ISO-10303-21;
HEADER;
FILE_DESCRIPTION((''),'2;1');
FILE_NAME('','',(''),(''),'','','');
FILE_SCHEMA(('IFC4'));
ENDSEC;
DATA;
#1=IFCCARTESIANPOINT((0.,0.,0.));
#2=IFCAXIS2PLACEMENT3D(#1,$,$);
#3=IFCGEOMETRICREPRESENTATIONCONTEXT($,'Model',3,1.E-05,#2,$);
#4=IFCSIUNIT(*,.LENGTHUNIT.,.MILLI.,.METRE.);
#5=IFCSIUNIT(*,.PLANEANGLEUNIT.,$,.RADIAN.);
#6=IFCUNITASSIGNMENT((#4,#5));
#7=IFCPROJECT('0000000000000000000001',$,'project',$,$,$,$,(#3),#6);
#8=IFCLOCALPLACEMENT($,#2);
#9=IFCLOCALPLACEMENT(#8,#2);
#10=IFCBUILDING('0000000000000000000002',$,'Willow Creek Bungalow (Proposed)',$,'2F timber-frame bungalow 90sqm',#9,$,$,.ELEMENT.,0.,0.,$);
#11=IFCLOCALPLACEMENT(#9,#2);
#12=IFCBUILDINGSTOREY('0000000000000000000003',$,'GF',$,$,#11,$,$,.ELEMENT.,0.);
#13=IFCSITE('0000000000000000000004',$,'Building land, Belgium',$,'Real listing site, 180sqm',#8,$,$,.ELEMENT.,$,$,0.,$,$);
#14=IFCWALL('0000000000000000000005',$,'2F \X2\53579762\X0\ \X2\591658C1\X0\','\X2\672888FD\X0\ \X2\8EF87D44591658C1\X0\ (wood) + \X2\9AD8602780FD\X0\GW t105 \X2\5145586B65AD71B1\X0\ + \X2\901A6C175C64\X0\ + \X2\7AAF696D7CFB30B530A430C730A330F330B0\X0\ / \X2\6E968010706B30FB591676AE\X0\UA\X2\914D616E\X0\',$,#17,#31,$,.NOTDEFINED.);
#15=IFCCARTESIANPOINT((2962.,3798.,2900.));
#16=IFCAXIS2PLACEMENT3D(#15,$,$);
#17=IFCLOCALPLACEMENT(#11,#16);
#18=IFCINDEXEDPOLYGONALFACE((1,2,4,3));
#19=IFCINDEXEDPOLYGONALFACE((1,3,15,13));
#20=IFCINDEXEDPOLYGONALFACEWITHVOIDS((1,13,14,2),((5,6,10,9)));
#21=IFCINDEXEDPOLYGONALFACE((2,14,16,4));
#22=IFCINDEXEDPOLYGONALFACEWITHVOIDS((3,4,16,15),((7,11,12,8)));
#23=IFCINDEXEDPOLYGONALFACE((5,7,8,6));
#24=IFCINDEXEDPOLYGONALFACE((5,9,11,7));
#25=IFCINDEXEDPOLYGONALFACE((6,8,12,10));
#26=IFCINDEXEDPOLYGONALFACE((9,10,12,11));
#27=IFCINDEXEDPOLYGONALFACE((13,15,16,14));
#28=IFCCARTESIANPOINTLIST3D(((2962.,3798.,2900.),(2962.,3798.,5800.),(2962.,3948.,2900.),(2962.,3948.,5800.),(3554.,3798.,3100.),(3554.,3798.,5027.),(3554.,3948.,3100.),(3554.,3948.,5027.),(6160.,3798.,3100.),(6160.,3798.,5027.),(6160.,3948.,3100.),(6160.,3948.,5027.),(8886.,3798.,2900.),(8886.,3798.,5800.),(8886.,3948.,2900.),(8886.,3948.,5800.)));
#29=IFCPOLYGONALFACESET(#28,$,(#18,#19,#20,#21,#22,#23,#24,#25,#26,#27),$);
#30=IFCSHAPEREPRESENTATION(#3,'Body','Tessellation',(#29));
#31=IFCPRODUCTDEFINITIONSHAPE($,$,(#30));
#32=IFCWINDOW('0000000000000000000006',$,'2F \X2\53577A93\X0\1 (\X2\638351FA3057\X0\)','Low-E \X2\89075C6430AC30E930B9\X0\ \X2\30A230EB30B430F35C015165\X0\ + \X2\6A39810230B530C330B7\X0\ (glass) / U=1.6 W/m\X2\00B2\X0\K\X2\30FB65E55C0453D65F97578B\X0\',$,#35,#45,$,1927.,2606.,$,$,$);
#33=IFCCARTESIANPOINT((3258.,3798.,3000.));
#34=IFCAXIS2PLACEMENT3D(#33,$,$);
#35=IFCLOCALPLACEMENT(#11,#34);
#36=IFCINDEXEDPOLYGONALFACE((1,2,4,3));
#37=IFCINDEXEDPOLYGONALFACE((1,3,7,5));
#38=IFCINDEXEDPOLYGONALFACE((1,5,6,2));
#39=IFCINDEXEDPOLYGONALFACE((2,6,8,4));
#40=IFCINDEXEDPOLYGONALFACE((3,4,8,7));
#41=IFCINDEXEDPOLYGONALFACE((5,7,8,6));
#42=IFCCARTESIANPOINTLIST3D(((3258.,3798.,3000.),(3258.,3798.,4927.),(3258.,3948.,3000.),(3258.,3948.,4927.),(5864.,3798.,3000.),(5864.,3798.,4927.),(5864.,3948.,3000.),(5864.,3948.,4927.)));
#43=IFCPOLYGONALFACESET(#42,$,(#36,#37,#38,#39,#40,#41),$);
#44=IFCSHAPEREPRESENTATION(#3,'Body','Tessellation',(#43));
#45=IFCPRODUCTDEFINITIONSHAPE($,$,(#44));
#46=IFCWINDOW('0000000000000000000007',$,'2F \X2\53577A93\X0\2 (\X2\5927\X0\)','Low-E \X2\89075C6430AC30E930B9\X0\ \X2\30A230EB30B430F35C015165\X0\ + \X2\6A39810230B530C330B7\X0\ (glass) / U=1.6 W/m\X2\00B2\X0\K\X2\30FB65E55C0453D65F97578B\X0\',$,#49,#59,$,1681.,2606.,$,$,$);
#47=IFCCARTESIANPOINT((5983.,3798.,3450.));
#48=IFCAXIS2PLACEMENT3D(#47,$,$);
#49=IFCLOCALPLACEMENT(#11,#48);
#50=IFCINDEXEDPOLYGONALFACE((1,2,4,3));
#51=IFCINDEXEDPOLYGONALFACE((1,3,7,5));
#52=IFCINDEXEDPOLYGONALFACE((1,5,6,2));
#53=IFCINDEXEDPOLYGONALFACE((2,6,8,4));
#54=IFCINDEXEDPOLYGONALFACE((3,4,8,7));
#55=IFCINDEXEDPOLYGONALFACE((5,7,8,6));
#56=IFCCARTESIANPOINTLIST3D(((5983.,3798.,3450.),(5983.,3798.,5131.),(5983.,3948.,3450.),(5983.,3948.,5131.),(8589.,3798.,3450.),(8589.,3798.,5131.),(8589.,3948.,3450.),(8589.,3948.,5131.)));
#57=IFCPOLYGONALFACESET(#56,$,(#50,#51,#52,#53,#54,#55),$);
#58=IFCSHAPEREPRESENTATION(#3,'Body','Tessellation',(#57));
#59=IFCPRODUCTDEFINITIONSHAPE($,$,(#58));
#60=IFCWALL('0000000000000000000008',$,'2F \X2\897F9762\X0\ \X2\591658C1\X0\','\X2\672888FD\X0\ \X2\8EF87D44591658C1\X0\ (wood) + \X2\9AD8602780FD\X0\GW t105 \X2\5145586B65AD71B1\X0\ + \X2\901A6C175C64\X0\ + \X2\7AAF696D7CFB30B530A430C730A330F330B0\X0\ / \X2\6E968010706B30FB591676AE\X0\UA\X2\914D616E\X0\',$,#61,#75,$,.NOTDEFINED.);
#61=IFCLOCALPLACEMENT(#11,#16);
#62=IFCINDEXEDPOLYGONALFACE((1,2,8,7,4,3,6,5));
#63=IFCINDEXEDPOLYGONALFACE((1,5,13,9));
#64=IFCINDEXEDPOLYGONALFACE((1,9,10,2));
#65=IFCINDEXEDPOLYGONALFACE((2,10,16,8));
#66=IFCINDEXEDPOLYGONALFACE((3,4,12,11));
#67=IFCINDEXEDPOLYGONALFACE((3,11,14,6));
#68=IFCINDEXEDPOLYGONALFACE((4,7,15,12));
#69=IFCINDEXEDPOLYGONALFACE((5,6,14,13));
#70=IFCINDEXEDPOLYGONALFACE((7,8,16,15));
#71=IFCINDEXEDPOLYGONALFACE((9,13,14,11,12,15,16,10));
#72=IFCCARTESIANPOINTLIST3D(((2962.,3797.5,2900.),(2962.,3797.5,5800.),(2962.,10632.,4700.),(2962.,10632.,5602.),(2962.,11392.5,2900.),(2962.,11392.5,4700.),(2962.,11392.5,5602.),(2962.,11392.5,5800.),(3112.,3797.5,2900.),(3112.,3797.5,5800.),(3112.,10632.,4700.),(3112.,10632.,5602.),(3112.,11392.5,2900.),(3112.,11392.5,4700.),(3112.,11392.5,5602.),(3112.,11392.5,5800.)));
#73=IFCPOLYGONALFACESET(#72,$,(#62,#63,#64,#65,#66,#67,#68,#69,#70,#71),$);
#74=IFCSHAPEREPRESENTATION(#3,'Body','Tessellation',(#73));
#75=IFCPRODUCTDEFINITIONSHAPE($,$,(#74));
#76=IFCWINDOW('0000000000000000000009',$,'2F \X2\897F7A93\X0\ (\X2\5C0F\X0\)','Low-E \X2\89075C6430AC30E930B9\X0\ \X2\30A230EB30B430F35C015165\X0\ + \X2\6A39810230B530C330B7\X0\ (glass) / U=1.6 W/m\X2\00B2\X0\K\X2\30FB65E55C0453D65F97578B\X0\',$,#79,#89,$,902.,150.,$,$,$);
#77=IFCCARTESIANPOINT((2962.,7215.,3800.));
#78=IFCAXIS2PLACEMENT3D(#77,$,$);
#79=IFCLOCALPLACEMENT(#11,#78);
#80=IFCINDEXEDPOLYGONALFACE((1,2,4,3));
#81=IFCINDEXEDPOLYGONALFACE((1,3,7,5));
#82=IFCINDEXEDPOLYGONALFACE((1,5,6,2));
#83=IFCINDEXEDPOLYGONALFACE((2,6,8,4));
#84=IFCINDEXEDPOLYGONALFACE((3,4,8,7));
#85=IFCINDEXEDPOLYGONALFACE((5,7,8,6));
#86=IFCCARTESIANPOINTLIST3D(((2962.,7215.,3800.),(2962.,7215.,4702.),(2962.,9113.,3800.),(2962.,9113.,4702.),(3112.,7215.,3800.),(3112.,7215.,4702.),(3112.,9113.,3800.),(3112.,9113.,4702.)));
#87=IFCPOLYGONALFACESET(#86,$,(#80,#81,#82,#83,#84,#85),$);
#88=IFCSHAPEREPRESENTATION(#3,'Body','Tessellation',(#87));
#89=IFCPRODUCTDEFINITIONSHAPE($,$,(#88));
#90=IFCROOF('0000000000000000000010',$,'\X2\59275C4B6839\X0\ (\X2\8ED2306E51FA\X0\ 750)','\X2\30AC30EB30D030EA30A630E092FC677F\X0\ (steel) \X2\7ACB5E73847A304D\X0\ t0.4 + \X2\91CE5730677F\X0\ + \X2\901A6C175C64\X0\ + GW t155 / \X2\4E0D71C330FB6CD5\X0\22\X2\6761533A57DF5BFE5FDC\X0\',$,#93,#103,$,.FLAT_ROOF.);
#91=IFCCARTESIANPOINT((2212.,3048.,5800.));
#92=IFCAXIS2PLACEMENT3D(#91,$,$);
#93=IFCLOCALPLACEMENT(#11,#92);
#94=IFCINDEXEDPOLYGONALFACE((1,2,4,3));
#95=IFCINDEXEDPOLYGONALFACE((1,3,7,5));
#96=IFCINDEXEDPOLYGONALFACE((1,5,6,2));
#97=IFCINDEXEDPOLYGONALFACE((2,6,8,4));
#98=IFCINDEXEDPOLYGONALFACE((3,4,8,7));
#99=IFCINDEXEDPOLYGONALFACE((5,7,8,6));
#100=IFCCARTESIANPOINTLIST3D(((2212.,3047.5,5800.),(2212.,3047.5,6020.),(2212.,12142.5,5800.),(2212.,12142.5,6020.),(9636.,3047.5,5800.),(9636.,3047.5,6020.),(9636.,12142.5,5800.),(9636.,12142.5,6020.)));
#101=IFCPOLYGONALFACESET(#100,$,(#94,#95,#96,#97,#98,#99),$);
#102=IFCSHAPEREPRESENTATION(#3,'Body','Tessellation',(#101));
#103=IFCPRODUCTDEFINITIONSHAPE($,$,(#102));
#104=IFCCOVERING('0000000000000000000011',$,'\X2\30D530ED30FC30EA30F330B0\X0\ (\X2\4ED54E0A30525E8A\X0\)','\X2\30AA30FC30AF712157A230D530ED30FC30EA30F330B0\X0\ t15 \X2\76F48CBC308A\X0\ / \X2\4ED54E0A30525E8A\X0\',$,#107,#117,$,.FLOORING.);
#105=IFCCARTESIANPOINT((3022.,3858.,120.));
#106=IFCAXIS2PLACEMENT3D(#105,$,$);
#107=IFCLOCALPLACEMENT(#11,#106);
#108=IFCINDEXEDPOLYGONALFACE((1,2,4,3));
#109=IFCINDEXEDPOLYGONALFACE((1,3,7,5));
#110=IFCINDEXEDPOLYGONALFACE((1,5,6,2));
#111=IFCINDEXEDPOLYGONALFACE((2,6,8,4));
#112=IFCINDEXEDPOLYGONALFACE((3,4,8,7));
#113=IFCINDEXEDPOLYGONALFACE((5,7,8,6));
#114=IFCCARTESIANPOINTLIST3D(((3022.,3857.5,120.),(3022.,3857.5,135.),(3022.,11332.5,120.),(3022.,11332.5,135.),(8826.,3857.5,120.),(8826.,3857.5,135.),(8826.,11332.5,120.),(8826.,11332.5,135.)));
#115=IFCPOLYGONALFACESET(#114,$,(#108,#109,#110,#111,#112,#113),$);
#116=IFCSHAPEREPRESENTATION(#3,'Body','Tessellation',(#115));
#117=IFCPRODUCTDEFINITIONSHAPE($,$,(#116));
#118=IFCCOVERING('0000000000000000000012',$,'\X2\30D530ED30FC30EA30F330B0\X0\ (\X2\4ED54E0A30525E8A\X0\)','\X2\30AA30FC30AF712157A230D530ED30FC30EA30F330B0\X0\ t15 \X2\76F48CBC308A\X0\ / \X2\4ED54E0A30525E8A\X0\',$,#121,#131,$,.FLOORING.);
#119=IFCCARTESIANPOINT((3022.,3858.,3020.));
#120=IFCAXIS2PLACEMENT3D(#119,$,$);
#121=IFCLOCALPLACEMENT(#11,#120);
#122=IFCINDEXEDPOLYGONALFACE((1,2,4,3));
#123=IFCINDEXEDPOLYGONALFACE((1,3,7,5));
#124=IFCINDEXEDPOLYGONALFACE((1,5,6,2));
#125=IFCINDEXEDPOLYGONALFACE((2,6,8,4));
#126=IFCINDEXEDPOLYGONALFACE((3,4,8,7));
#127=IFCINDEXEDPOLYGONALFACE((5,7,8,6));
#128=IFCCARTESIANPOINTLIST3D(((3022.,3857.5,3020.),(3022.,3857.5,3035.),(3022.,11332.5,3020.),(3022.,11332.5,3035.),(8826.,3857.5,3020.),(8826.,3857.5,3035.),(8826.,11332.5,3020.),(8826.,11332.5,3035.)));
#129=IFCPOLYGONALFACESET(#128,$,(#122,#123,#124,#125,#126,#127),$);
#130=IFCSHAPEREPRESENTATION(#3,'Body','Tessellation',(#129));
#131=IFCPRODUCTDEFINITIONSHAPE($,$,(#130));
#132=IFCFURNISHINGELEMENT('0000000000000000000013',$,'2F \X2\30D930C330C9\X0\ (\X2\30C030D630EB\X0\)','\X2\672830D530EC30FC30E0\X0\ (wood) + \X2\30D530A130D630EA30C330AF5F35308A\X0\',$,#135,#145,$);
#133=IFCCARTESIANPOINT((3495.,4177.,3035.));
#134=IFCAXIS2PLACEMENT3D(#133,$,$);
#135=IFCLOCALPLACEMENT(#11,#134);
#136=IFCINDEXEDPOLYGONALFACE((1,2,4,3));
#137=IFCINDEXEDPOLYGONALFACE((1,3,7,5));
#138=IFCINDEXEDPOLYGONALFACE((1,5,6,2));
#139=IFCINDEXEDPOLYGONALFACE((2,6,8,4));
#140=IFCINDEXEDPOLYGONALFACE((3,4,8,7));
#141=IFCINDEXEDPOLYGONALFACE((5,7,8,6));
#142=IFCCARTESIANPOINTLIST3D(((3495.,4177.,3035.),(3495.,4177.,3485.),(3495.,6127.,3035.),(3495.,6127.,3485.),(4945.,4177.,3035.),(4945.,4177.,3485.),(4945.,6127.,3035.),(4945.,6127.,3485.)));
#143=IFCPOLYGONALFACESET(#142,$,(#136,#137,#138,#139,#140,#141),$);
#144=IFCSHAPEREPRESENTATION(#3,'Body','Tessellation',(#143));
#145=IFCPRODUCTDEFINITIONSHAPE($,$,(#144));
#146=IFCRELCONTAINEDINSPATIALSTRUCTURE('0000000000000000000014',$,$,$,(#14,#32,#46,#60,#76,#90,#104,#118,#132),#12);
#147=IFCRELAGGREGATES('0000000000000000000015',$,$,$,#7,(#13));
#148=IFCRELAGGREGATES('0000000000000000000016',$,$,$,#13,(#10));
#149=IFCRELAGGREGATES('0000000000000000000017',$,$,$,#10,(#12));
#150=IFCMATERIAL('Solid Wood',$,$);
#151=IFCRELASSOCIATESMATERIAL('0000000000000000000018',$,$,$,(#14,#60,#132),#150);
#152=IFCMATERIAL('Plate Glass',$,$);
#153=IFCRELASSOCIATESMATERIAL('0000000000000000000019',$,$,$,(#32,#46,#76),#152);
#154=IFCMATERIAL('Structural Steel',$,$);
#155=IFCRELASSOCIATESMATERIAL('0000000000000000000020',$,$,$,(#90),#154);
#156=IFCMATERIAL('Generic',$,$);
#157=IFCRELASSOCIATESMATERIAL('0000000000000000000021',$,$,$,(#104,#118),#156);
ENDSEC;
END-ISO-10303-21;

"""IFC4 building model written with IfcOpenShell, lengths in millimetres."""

from ifc_helpers import new_model, si_unit, frame, frame_2d, origin, place, context, project, spatial, rectangle, extrude, material, element, fill, save


model = new_model("IFC4")

# Units and contexts
model_context = context("Model", 3, precision=1e-05, world=origin())
ifc_project = project(units=[si_unit("LENGTHUNIT", "METRE", prefix="MILLI"), si_unit("PLANEANGLEUNIT", "RADIAN")], contexts=[model_context])

# Site, building, storey
site_placement = place(None, origin())
site = spatial("IfcSite", under=ifc_project, at=site_placement, Name="Building land, Belgium", ObjectType="Real listing site, 180sqm", CompositionType="ELEMENT", RefElevation=0.0)
building_placement = place(site_placement, origin())
building = spatial("IfcBuilding", under=site, at=building_placement, Name="Willow Creek Bungalow (Proposed)", ObjectType="2F timber-frame bungalow 90sqm", CompositionType="ELEMENT", ElevationOfRefHeight=0.0, ElevationOfTerrain=0.0)
storey_placement = place(building_placement, origin())
storey = spatial("IfcBuildingStorey", under=building, at=storey_placement, Name="GF", CompositionType="ELEMENT", Elevation=0.0)

# Shared definitions
ifc_material_1 = material(Name="Solid Wood")

# Shared definitions
ifc_material_2 = material(Name="Plate Glass")

# Wall, openings, windows
wall_1_placement = place(storey_placement, frame((2962.0, 3798.0, 2900.0)))
wall_1 = element("IfcWall", 1, at=wall_1_placement, inside=storey, material=ifc_material_1, Name="2F 南面 外壁", Description="木製 軸組外壁 (wood) + 高性能GW t105 充填断熱 + 通気層 + 窯業系サイディング / 準耐火・外皮UA配慮", PredefinedType="NOTDEFINED", context=model_context, shape_type="SweptSolid", body=[
    extrude(rectangle(XDim=5924.0, YDim=150.0, at=frame_2d((2962.0, 75.0))), frame((2962.0, 3798.0, 2900.0)), (0.0, 0.0, 1.0), 2900.0),
])
opening_1_placement = place(storey_placement, frame((3258.0, 3798.0, 3000.0)))
opening_1 = element("IfcOpeningElement", 2, at=opening_1_placement, cuts=wall_1, PredefinedType="NOTDEFINED", context=model_context, shape_type="SweptSolid", body=[
    extrude(rectangle(XDim=2606.0, YDim=150.0, at=frame_2d((1303.0, 75.0))), frame((3258.0, 3798.0, 3000.0)), (0.0, 0.0, 1.0), 1927.0),
])
opening_2_placement = place(storey_placement, frame((5983.0, 3798.0, 3450.0)))
opening_2 = element("IfcOpeningElement", 3, at=opening_2_placement, cuts=wall_1, PredefinedType="NOTDEFINED", context=model_context, shape_type="SweptSolid", body=[
    extrude(rectangle(XDim=2606.0, YDim=150.0, at=frame_2d((1303.0, 75.0))), frame((5983.0, 3798.0, 3450.0)), (0.0, 0.0, 1.0), 1681.0),
])
window_1_placement = place(storey_placement, frame((3258.0, 3798.0, 3000.0)))
window_1 = element("IfcWindow", 4, at=window_1_placement, inside=storey, material=ifc_material_2, Name="2F 南窓1 (掃出し)", Description="Low-E 複層ガラス アルゴン封入 + 樹脂サッシ (glass) / U=1.6 W/m²K・日射取得型", OverallHeight=1927.0, OverallWidth=2606.0, context=model_context, shape_type="SweptSolid", body=[
    extrude(rectangle(XDim=2606.0, YDim=150.0, at=frame_2d((1303.0, 75.0))), frame((3258.0, 3798.0, 3000.0)), (0.0, 0.0, 1.0), 1927.0),
])
fill(opening_1, window_1)
window_2_placement = place(storey_placement, frame((5983.0, 3798.0, 3450.0)))
window_2 = element("IfcWindow", 5, at=window_2_placement, inside=storey, material=ifc_material_2, Name="2F 南窓2 (大)", Description="Low-E 複層ガラス アルゴン封入 + 樹脂サッシ (glass) / U=1.6 W/m²K・日射取得型", OverallHeight=1681.0, OverallWidth=2606.0, context=model_context, shape_type="SweptSolid", body=[
    extrude(rectangle(XDim=2606.0, YDim=150.0, at=frame_2d((1303.0, 75.0))), frame((5983.0, 3798.0, 3450.0)), (0.0, 0.0, 1.0), 1681.0),
])
fill(opening_2, window_2)

# Wall, opening, window
wall_2_placement = place(storey_placement, frame((2962.0, 3798.0, 2900.0)))
wall_2 = element("IfcWall", 6, at=wall_2_placement, inside=storey, material=ifc_material_1, Name="2F 西面 外壁", Description="木製 軸組外壁 (wood) + 高性能GW t105 充填断熱 + 通気層 + 窯業系サイディング / 準耐火・外皮UA配慮", PredefinedType="NOTDEFINED", context=model_context, shape_type="SweptSolid", body=[
    extrude(rectangle(XDim=150.0, YDim=7595.0, at=frame_2d((75.0, 3797.0))), frame((2962.0, 3798.0, 2900.0)), (0.0, 0.0, 1.0), 2900.0),
])
opening_3_placement = place(storey_placement, frame((2962.0, 7215.0, 3800.0)))
opening_3 = element("IfcOpeningElement", 7, at=opening_3_placement, cuts=wall_2, PredefinedType="NOTDEFINED", context=model_context, shape_type="SweptSolid", body=[
    extrude(rectangle(XDim=150.0, YDim=1898.0, at=frame_2d((75.0, 949.0))), frame((2962.0, 7215.0, 3800.0)), (0.0, 0.0, 1.0), 902.0),
])
window_3_placement = place(storey_placement, frame((2962.0, 7215.0, 3800.0)))
window_3 = element("IfcWindow", 8, at=window_3_placement, inside=storey, material=ifc_material_2, Name="2F 西窓 (小)", Description="Low-E 複層ガラス アルゴン封入 + 樹脂サッシ (glass) / U=1.6 W/m²K・日射取得型", OverallHeight=902.0, OverallWidth=150.0, context=model_context, shape_type="SweptSolid", body=[
    extrude(rectangle(XDim=150.0, YDim=1898.0, at=frame_2d((75.0, 949.0))), frame((2962.0, 7215.0, 3800.0)), (0.0, 0.0, 1.0), 902.0),
])
fill(opening_3, window_3)

# Roof
ifc_material_3 = material(Name="Structural Steel")
roof_placement = place(storey_placement, frame((2212.0, 3048.0, 5800.0)))
element("IfcRoof", 9, at=roof_placement, inside=storey, material=ifc_material_3, Name="大屋根 (軒の出 750)", Description="ガルバリウム鋼板 (steel) 立平葺き t0.4 + 野地板 + 通気層 + GW t155 / 不燃・法22条区域対応", PredefinedType="FLAT_ROOF", context=model_context, shape_type="SweptSolid", body=[
    extrude(rectangle(XDim=7424.0, YDim=9095.0, at=frame_2d((3712.0, 4547.0))), frame((2212.0, 3048.0, 5800.0)), (0.0, 0.0, 1.0), 220.0),
])

# Coverings
ifc_material_4 = material(Name="Generic")
covering_1_placement = place(storey_placement, frame((3022.0, 3858.0, 120.0)))
element("IfcCovering", 10, at=covering_1_placement, inside=storey, material=ifc_material_4, Name="フローリング (仕上げ床)", Description="オーク無垢フローリング t15 直貼り / 仕上げ床", PredefinedType="FLOORING", context=model_context, shape_type="SweptSolid", body=[
    extrude(rectangle(XDim=5804.0, YDim=7475.0, at=frame_2d((2902.0, 3737.0))), frame((3022.0, 3858.0, 120.0)), (0.0, 0.0, 1.0), 15.0),
])
covering_2_placement = place(storey_placement, frame((3022.0, 3858.0, 3020.0)))
element("IfcCovering", 11, at=covering_2_placement, inside=storey, material=ifc_material_4, Name="フローリング (仕上げ床)", Description="オーク無垢フローリング t15 直貼り / 仕上げ床", PredefinedType="FLOORING", context=model_context, shape_type="SweptSolid", body=[
    extrude(rectangle(XDim=5804.0, YDim=7475.0, at=frame_2d((2902.0, 3737.0))), frame((3022.0, 3858.0, 3020.0)), (0.0, 0.0, 1.0), 15.0),
])

# Furnishing element
furnishing_placement = place(storey_placement, frame((3495.0, 4177.0, 3035.0)))
element("IfcFurnishingElement", 12, at=furnishing_placement, inside=storey, material=ifc_material_1, Name="2F ベッド (ダブル)", Description="木フレーム (wood) + ファブリック張り", context=model_context, shape_type="SweptSolid", body=[
    extrude(rectangle(XDim=1450.0, YDim=1950.0, at=frame_2d((725.0, 975.0))), frame((3495.0, 4177.0, 3035.0)), (0.0, 0.0, 1.0), 450.0),
])

save(model, "model.ifc")
